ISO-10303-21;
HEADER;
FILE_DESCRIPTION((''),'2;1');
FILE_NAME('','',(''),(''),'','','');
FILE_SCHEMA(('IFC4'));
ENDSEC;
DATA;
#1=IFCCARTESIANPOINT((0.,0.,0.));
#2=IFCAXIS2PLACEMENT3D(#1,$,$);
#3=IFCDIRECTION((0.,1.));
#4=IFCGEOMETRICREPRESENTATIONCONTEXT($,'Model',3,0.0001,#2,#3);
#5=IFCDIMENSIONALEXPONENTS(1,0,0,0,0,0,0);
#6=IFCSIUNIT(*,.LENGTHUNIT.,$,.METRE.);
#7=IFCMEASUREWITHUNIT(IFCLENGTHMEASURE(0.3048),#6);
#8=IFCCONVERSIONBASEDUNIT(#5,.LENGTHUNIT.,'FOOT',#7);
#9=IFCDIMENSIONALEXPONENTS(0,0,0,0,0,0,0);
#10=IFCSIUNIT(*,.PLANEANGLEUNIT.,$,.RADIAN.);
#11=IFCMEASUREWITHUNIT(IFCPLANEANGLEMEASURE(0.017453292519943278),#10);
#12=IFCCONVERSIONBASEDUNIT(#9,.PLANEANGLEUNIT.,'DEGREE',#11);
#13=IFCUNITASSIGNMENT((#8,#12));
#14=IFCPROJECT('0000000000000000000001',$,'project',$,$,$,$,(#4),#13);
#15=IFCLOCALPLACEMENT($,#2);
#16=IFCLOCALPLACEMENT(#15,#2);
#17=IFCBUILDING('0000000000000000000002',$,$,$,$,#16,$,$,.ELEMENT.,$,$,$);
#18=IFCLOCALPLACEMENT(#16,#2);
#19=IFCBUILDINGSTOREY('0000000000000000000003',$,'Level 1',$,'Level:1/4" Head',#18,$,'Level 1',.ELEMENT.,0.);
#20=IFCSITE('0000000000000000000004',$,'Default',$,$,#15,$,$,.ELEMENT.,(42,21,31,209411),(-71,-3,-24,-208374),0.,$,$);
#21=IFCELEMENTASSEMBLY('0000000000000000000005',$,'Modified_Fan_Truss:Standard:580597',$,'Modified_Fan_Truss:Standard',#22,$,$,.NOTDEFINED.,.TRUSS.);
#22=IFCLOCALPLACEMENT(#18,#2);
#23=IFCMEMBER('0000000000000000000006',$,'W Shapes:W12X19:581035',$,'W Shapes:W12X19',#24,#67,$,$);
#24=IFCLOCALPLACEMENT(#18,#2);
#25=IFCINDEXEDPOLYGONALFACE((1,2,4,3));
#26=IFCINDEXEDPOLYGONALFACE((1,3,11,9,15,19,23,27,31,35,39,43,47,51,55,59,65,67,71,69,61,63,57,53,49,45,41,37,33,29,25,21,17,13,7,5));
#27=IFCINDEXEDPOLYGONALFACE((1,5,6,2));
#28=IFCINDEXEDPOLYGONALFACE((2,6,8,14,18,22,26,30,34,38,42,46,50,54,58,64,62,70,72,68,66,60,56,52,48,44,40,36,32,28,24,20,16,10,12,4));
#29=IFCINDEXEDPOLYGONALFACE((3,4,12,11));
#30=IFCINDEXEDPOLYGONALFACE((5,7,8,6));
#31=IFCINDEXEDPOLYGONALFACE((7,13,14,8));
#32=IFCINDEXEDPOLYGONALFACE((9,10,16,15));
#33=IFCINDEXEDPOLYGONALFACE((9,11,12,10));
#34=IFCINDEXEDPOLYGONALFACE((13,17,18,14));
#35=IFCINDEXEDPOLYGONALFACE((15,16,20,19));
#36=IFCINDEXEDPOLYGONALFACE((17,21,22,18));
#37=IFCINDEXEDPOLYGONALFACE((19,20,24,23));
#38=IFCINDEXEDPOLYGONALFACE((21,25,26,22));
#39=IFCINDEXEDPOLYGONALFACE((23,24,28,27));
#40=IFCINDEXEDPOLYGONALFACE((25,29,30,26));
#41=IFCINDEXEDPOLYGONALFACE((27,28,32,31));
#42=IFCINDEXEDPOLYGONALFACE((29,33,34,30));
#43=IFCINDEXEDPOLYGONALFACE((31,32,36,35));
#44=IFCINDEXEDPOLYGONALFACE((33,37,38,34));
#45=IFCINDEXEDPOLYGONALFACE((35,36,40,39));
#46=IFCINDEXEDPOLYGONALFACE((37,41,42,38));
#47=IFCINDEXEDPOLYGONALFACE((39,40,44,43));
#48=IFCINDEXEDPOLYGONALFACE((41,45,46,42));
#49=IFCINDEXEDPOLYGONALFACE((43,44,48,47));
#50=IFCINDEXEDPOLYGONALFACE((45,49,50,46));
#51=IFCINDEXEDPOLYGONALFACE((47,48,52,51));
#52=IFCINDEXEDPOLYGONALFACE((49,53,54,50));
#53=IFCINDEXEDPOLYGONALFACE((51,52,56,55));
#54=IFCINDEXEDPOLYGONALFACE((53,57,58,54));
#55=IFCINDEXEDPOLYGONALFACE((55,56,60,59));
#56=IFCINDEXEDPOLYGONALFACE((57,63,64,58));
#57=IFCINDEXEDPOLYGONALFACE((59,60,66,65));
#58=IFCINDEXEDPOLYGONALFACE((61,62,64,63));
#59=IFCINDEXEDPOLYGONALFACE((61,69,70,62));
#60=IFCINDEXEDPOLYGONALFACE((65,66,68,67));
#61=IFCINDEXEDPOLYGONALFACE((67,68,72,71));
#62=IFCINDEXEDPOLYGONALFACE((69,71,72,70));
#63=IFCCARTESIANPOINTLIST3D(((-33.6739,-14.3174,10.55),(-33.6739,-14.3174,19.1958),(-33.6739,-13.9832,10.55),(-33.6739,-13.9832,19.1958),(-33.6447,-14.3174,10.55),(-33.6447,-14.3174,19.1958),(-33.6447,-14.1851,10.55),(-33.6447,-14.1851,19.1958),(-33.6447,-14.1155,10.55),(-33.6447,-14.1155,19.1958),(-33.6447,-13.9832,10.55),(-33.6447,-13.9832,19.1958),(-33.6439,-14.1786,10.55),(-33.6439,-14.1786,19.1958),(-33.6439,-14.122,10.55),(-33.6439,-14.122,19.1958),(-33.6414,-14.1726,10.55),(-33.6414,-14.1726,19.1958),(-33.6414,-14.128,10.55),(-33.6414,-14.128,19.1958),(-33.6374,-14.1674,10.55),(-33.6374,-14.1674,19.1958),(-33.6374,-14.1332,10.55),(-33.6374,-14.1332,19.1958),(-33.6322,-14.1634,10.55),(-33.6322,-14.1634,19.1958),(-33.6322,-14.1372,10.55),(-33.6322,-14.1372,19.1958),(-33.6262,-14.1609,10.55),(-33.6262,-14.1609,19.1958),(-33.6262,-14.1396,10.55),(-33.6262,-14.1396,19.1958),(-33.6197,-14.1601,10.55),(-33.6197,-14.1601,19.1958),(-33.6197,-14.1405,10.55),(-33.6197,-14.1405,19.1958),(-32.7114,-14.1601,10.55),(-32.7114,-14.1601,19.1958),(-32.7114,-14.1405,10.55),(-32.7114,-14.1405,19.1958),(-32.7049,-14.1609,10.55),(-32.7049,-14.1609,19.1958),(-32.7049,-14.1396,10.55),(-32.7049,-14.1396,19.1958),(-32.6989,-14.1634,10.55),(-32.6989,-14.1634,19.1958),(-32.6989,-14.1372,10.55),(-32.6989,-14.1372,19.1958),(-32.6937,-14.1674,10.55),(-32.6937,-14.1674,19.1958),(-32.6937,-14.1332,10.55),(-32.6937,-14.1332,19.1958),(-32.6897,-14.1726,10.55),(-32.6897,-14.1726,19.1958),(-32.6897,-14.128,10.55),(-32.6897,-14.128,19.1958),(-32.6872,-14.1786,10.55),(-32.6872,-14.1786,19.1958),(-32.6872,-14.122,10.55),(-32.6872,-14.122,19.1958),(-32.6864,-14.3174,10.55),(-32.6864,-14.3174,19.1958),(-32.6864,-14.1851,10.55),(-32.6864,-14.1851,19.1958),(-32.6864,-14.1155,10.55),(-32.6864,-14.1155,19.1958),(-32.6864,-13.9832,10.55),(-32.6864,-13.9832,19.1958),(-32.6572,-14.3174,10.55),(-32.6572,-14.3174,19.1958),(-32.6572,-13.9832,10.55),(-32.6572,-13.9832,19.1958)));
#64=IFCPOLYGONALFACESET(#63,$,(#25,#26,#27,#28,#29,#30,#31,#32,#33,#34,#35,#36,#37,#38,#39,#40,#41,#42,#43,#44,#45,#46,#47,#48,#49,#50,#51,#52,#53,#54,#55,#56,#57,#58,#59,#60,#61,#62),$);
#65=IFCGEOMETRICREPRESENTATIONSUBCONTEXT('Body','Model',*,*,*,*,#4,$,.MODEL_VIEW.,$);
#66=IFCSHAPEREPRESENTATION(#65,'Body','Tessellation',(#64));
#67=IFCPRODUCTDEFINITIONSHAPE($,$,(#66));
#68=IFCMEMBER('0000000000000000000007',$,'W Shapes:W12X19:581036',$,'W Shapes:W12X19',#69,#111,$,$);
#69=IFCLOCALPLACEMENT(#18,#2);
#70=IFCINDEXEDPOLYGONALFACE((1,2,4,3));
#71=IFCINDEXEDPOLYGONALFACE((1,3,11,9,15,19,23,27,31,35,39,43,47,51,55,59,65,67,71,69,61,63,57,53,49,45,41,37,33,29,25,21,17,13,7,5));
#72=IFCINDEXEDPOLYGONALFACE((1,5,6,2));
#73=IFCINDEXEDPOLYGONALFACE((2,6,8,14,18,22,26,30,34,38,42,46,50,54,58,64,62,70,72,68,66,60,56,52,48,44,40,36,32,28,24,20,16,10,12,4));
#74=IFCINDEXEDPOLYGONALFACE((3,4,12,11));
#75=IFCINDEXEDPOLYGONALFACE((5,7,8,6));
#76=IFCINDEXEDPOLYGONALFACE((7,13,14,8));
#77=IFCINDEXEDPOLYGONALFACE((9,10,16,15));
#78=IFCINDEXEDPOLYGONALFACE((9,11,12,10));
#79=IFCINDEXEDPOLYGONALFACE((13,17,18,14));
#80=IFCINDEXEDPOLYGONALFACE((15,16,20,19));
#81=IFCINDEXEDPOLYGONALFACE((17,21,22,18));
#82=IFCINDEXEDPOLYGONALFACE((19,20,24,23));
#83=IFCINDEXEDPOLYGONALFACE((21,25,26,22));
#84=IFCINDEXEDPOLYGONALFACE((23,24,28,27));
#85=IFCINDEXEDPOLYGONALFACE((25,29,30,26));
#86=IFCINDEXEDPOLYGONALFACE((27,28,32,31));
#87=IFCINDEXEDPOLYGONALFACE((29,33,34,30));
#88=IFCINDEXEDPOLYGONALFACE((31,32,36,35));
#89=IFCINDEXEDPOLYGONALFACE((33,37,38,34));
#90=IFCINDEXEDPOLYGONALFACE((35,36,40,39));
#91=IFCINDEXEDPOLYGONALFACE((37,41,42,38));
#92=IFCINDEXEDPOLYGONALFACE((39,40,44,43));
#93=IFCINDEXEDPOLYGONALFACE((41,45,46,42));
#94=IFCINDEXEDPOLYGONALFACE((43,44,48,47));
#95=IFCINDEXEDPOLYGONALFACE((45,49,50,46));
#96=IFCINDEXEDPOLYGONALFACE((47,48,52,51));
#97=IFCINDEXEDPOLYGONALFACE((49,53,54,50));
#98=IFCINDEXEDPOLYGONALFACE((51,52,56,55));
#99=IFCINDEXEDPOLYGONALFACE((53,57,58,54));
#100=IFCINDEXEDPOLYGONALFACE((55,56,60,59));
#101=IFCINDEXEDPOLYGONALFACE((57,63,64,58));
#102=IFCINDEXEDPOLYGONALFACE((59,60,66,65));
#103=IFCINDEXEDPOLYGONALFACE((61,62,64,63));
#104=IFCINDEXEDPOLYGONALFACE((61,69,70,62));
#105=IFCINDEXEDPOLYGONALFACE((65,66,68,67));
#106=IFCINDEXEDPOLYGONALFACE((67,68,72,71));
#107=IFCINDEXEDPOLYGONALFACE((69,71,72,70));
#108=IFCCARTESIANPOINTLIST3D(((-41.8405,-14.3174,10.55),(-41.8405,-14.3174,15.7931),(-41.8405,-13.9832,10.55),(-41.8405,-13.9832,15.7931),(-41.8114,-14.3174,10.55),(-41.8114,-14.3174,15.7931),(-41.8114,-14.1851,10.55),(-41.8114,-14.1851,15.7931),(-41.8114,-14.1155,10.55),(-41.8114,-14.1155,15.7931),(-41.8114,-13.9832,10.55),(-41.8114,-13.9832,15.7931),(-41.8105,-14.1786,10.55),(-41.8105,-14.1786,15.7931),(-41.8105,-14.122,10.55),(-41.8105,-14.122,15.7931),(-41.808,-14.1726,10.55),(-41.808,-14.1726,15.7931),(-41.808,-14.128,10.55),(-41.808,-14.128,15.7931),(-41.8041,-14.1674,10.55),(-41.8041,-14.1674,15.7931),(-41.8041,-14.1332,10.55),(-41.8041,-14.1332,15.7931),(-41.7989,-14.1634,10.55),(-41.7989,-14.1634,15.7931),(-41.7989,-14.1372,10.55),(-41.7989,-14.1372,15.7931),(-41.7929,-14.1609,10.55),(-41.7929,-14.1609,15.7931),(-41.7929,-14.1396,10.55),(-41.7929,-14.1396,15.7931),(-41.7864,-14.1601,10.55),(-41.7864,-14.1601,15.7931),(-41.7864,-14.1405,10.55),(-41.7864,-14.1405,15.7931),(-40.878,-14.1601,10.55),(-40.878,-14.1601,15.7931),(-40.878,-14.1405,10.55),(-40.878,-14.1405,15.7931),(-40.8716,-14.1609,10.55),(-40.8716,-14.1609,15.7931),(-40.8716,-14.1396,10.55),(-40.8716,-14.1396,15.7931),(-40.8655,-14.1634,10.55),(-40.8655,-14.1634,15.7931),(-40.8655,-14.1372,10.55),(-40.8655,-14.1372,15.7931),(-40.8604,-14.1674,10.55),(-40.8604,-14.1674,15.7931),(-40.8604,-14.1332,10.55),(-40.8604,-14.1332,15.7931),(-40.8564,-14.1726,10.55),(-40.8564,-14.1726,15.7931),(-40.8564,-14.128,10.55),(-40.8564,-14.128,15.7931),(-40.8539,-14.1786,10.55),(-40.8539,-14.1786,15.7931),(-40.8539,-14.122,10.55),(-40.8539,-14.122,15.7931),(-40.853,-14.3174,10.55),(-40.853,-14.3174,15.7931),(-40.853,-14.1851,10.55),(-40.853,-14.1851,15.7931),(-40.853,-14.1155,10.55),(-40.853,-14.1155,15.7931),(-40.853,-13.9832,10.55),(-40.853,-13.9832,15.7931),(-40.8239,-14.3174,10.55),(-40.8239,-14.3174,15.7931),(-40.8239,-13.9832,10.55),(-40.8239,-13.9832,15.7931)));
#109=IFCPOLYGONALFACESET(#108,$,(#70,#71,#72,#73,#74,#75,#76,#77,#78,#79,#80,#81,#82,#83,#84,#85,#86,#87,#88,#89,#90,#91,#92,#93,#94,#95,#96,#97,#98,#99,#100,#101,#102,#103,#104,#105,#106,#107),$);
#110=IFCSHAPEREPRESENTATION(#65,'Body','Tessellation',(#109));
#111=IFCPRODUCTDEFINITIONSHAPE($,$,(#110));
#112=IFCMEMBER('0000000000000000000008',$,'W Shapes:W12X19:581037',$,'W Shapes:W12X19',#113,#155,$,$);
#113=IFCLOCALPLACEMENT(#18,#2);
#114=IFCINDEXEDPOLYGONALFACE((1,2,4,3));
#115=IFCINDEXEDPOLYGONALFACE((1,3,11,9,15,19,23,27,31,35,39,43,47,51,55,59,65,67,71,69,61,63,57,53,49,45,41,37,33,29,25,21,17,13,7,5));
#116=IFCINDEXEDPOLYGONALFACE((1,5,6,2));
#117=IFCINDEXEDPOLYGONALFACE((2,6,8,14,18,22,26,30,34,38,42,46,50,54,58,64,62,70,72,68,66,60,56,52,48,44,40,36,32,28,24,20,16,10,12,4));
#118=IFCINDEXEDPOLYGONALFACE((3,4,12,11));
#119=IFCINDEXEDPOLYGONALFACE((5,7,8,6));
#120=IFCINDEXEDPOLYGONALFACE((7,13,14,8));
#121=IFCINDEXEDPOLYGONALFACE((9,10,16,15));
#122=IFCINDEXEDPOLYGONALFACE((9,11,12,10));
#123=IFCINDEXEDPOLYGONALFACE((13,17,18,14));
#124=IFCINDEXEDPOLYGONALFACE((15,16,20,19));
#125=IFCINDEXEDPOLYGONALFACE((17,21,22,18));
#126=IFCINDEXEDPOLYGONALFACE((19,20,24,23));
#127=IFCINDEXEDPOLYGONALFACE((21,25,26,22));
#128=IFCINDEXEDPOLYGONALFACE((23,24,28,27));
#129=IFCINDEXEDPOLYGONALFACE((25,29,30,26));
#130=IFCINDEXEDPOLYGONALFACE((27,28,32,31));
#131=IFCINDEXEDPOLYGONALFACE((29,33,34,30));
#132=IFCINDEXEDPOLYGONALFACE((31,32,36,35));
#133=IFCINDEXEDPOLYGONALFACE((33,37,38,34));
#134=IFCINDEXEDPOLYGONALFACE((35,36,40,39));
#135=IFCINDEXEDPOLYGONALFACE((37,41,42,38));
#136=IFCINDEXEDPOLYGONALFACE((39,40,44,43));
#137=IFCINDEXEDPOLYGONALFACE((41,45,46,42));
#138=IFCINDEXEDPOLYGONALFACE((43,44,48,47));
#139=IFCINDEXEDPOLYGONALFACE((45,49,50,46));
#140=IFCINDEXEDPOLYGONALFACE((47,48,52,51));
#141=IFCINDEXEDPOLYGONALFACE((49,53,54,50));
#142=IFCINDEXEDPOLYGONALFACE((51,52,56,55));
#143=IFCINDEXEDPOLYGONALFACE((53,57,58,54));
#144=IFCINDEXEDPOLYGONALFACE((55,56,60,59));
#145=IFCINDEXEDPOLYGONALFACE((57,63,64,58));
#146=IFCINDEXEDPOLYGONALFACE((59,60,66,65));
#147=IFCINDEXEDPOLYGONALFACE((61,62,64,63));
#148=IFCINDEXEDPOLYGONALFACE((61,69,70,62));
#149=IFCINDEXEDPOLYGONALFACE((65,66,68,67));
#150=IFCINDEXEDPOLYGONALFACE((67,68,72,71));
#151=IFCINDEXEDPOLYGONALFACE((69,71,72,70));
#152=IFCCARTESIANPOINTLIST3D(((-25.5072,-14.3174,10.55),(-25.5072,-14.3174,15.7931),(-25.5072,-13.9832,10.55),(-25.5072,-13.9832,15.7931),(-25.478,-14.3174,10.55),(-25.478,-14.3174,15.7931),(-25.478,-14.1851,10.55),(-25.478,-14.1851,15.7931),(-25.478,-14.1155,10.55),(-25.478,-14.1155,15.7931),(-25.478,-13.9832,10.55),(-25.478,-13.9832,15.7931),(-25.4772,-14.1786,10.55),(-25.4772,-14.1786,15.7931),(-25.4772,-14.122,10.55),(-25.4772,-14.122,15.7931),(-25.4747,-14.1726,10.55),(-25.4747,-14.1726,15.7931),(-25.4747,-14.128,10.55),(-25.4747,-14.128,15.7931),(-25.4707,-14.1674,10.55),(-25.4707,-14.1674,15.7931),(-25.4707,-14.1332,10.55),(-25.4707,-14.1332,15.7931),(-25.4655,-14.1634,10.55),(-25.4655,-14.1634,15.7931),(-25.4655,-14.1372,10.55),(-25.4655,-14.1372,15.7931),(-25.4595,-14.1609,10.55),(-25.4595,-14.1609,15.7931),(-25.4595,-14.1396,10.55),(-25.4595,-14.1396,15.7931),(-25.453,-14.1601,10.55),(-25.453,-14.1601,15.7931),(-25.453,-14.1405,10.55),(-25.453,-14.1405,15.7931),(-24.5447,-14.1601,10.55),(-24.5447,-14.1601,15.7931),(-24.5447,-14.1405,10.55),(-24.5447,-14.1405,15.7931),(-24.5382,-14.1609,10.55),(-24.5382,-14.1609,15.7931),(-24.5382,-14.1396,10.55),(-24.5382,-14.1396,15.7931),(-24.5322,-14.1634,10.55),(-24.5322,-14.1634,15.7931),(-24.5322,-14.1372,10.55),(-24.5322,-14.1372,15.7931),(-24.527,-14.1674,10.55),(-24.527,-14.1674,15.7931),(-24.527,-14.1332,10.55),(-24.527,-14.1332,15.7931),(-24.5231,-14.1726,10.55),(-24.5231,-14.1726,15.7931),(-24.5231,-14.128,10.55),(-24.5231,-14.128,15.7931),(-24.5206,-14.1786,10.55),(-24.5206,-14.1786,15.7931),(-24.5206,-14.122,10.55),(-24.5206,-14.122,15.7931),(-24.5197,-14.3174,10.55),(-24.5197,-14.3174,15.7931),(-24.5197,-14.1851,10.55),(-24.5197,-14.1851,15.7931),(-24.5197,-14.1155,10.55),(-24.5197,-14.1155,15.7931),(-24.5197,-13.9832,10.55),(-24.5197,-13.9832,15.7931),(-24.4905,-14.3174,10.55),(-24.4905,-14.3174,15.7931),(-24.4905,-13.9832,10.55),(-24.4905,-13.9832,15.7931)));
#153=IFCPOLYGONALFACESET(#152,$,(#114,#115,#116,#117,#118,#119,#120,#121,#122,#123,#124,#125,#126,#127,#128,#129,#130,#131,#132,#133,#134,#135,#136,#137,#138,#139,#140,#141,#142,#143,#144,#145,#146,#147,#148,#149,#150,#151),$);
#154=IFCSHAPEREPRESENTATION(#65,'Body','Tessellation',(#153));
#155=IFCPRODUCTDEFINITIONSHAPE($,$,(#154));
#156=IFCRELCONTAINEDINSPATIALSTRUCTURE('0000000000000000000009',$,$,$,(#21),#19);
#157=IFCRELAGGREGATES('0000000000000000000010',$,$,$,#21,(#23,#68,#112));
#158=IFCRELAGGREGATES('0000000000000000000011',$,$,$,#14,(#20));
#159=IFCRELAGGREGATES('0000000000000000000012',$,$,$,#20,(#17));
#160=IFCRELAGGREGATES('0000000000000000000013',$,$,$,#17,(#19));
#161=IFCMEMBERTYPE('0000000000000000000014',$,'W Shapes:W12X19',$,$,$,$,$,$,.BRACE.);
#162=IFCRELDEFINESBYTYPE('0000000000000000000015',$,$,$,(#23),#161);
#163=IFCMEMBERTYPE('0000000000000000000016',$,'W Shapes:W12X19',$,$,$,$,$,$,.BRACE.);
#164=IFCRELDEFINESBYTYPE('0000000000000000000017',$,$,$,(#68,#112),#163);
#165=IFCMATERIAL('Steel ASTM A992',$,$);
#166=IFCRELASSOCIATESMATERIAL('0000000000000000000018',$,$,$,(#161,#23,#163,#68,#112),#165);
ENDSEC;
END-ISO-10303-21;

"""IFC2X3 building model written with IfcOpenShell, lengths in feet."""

from ifc_helpers import new_model, entity, si_unit, converted_unit, direction, frame, frame_2d, origin, place, context, subcontext, project, spatial, polyline, circle_curve, parameter, trimmed, segment, composite_curve, outline, extrude, source, transform, mapped, material, type_object, type_shapes, element, aggregate, save


model = new_model("IFC2X3")

# Units and contexts
model_context = context("Model", 3, precision=0.0001, world=origin(), true_north=direction((0.0, 1.0)))
body_context = subcontext(model_context, "Body", "Model", "MODEL_VIEW")
ifc_project = project(units=[converted_unit("LENGTHUNIT", "FOOT", entity("IfcLengthMeasure", 0.3048), si_unit("LENGTHUNIT", "METRE"), dimensions=[1, 0, 0, 0, 0, 0, 0]), converted_unit("PLANEANGLEUNIT", "DEGREE", entity("IfcPlaneAngleMeasure", 0.017453292519943278), si_unit("PLANEANGLEUNIT", "RADIAN"), dimensions=[0, 0, 0, 0, 0, 0, 0])], contexts=[model_context])

# Site, building, storey
site_placement = place(None, origin())
site = spatial("IfcSite", under=ifc_project, at=site_placement, Name="Default", CompositionType="ELEMENT", RefLatitude=(42, 21, 31, 209411), RefLongitude=(-71, -3, -24, -208374), RefElevation=0.0)
building_placement = place(site_placement, origin())
building = spatial("IfcBuilding", under=site, at=building_placement, CompositionType="ELEMENT")
storey_placement = place(building_placement, origin())
storey = spatial("IfcBuildingStorey", under=building, at=storey_placement, Name="Level 1", ObjectType="Level:1/4\" Head", LongName="Level 1", CompositionType="ELEMENT", Elevation=0.0)

# Element assembly, members
assembly_placement = place(storey_placement, origin())
assembly = element("IfcElementAssembly", 1, at=assembly_placement, inside=storey, Name="Modified_Fan_Truss:Standard:580597", ObjectType="Modified_Fan_Truss:Standard", AssemblyPlace="NOTDEFINED", PredefinedType="TRUSS")
ifc_material = material(Name="Steel ASTM A992")
member_type_1 = type_object("IfcMemberType", Name="W Shapes:W12X19", PredefinedType="BRACE", material=ifc_material)
shared_shape_1 = source(origin(), body_context, "Body", "SweptSolid", [
    extrude(outline(composite_curve([segment(polyline([(-0.1671, -0.4792), (-0.1671, -0.5083)]), True, "CONTINUOUS"), segment(polyline([(-0.1671, -0.5083), (0.1671, -0.5083)]), True, "CONTINUOUS"), segment(polyline([(0.1671, -0.5083), (0.1671, -0.4792)]), True, "CONTINUOUS"), segment(polyline([(0.1671, -0.4792), (0.0348, -0.4792)]), True, "CONTINUOUS"), segment(trimmed(circle_curve(frame_2d((0.0348, -0.4542), x_axis=(1.0, 0.0)), 0.025), [parameter(180.0)], [parameter(270.0)], True, "PARAMETER"), False, "CONTINUOUS"), segment(polyline([(0.0098, -0.4542), (0.0098, 0.4542)]), True, "CONTINUOUS"), segment(trimmed(circle_curve(frame_2d((0.0348, 0.4542), x_axis=(1.0, 0.0)), 0.025), [parameter(90.0)], [parameter(180.0)], True, "PARAMETER"), False, "CONTINUOUS"), segment(polyline([(0.0348, 0.4792), (0.1671, 0.4792)]), True, "CONTINUOUS"), segment(polyline([(0.1671, 0.4792), (0.1671, 0.5083)]), True, "CONTINUOUS"), segment(polyline([(0.1671, 0.5083), (-0.1671, 0.5083)]), True, "CONTINUOUS"), segment(polyline([(-0.1671, 0.5083), (-0.1671, 0.4792)]), True, "CONTINUOUS"), segment(polyline([(-0.1671, 0.4792), (-0.0348, 0.4792)]), True, "CONTINUOUS"), segment(trimmed(circle_curve(frame_2d((-0.0348, 0.4542), x_axis=(1.0, 0.0)), 0.025), [parameter(360.0)], [parameter(90.0)], True, "PARAMETER"), False, "CONTINUOUS"), segment(polyline([(-0.0098, 0.4542), (-0.0098, -0.4542)]), True, "CONTINUOUS"), segment(trimmed(circle_curve(frame_2d((-0.0348, -0.4542), x_axis=(1.0, 0.0)), 0.025), [parameter(270.0)], [parameter(360.0)], True, "PARAMETER"), False, "CONTINUOUS"), segment(polyline([(-0.0348, -0.4792), (-0.1671, -0.4792)]), True, "CONTINUOUS")], self_intersect=False)), frame((-4.45, 0.0, 0.0), z_axis=(-1.0, 0.0, 0.0), x_axis=(0.0, -1.0, 0.0)), (0.0, 0.0, -1.0), 8.6458),
])
type_shapes(member_type_1, [shared_shape_1])
member_1_placement = place(assembly_placement, frame((-33.1655, -14.1503, 15.0), z_axis=(1.0, 0.0, 0.0), x_axis=(0.0, 0.0, 1.0)))
member_1 = element("IfcMember", 2, at=member_1_placement, type_object=member_type_1, material=ifc_material, Name="W Shapes:W12X19:581035", ObjectType="W Shapes:W12X19", context=body_context, shape_type="MappedRepresentation", body=[
    mapped(shared_shape_1, transform((0.0, 0.0, 0.0), scale=1.0)),
])
member_type_2 = type_object("IfcMemberType", Name="W Shapes:W12X19", PredefinedType="BRACE", material=ifc_material)
shared_shape_2 = source(origin(), body_context, "Body", "SweptSolid", [
    extrude(outline(composite_curve([segment(polyline([(-0.1671, -0.4792), (-0.1671, -0.5083)]), True, "CONTINUOUS"), segment(polyline([(-0.1671, -0.5083), (0.1671, -0.5083)]), True, "CONTINUOUS"), segment(polyline([(0.1671, -0.5083), (0.1671, -0.4792)]), True, "CONTINUOUS"), segment(polyline([(0.1671, -0.4792), (0.0348, -0.4792)]), True, "CONTINUOUS"), segment(trimmed(circle_curve(frame_2d((0.0348, -0.4542), x_axis=(0.0, -1.0)), 0.025), [parameter(270.0)], [parameter(360.0)], True, "PARAMETER"), False, "CONTINUOUS"), segment(polyline([(0.0098, -0.4542), (0.0098, 0.4542)]), True, "CONTINUOUS"), segment(trimmed(circle_curve(frame_2d((0.0348, 0.4542), x_axis=(-1.0, 0.0)), 0.025), [parameter(270.0)], [parameter(360.0)], True, "PARAMETER"), False, "CONTINUOUS"), segment(polyline([(0.0348, 0.4792), (0.1671, 0.4792)]), True, "CONTINUOUS"), segment(polyline([(0.1671, 0.4792), (0.1671, 0.5083)]), True, "CONTINUOUS"), segment(polyline([(0.1671, 0.5083), (-0.1671, 0.5083)]), True, "CONTINUOUS"), segment(polyline([(-0.1671, 0.5083), (-0.1671, 0.4792)]), True, "CONTINUOUS"), segment(polyline([(-0.1671, 0.4792), (-0.0348, 0.4792)]), True, "CONTINUOUS"), segment(trimmed(circle_curve(frame_2d((-0.0348, 0.4542), x_axis=(0.0, 1.0)), 0.025), [parameter(270.0)], [parameter(0.0)], True, "PARAMETER"), False, "CONTINUOUS"), segment(polyline([(-0.0098, 0.4542), (-0.0098, -0.4542)]), True, "CONTINUOUS"), segment(trimmed(circle_curve(frame_2d((-0.0348, -0.4542), x_axis=(1.0, 0.0)), 0.025), [parameter(270.0)], [parameter(0.0)], True, "PARAMETER"), False, "CONTINUOUS"), segment(polyline([(-0.0348, -0.4792), (-0.1671, -0.4792)]), True, "CONTINUOUS")], self_intersect=False)), frame((-2.7486, 0.0, 0.0), z_axis=(-1.0, 0.0, 0.0), x_axis=(0.0, -1.0, 0.0)), (0.0, 0.0, -1.0), 5.2431),
])
type_shapes(member_type_2, [shared_shape_2])
member_2_placement = place(assembly_placement, frame((-41.3322, -14.1503, 13.2986), z_axis=(1.0, 0.0, 0.0), x_axis=(0.0, 0.0, 1.0)))
member_2 = element("IfcMember", 3, at=member_2_placement, type_object=member_type_2, material=ifc_material, Name="W Shapes:W12X19:581036", ObjectType="W Shapes:W12X19", context=body_context, shape_type="MappedRepresentation", body=[
    mapped(shared_shape_2, transform((0.0, 0.0, 0.0), scale=1.0)),
])
member_3_placement = place(assembly_placement, frame((-24.9989, -14.1503, 13.2986), z_axis=(1.0, 0.0, 0.0), x_axis=(0.0, 0.0, 1.0)))
member_3 = element("IfcMember", 4, at=member_3_placement, type_object=member_type_2, material=ifc_material, Name="W Shapes:W12X19:581037", ObjectType="W Shapes:W12X19", context=body_context, shape_type="MappedRepresentation", body=[
    mapped(shared_shape_2, transform((0.0, 0.0, 0.0), scale=1.0)),
])
aggregate(assembly, [member_1, member_2, member_3])

save(model, "model.ifc")
